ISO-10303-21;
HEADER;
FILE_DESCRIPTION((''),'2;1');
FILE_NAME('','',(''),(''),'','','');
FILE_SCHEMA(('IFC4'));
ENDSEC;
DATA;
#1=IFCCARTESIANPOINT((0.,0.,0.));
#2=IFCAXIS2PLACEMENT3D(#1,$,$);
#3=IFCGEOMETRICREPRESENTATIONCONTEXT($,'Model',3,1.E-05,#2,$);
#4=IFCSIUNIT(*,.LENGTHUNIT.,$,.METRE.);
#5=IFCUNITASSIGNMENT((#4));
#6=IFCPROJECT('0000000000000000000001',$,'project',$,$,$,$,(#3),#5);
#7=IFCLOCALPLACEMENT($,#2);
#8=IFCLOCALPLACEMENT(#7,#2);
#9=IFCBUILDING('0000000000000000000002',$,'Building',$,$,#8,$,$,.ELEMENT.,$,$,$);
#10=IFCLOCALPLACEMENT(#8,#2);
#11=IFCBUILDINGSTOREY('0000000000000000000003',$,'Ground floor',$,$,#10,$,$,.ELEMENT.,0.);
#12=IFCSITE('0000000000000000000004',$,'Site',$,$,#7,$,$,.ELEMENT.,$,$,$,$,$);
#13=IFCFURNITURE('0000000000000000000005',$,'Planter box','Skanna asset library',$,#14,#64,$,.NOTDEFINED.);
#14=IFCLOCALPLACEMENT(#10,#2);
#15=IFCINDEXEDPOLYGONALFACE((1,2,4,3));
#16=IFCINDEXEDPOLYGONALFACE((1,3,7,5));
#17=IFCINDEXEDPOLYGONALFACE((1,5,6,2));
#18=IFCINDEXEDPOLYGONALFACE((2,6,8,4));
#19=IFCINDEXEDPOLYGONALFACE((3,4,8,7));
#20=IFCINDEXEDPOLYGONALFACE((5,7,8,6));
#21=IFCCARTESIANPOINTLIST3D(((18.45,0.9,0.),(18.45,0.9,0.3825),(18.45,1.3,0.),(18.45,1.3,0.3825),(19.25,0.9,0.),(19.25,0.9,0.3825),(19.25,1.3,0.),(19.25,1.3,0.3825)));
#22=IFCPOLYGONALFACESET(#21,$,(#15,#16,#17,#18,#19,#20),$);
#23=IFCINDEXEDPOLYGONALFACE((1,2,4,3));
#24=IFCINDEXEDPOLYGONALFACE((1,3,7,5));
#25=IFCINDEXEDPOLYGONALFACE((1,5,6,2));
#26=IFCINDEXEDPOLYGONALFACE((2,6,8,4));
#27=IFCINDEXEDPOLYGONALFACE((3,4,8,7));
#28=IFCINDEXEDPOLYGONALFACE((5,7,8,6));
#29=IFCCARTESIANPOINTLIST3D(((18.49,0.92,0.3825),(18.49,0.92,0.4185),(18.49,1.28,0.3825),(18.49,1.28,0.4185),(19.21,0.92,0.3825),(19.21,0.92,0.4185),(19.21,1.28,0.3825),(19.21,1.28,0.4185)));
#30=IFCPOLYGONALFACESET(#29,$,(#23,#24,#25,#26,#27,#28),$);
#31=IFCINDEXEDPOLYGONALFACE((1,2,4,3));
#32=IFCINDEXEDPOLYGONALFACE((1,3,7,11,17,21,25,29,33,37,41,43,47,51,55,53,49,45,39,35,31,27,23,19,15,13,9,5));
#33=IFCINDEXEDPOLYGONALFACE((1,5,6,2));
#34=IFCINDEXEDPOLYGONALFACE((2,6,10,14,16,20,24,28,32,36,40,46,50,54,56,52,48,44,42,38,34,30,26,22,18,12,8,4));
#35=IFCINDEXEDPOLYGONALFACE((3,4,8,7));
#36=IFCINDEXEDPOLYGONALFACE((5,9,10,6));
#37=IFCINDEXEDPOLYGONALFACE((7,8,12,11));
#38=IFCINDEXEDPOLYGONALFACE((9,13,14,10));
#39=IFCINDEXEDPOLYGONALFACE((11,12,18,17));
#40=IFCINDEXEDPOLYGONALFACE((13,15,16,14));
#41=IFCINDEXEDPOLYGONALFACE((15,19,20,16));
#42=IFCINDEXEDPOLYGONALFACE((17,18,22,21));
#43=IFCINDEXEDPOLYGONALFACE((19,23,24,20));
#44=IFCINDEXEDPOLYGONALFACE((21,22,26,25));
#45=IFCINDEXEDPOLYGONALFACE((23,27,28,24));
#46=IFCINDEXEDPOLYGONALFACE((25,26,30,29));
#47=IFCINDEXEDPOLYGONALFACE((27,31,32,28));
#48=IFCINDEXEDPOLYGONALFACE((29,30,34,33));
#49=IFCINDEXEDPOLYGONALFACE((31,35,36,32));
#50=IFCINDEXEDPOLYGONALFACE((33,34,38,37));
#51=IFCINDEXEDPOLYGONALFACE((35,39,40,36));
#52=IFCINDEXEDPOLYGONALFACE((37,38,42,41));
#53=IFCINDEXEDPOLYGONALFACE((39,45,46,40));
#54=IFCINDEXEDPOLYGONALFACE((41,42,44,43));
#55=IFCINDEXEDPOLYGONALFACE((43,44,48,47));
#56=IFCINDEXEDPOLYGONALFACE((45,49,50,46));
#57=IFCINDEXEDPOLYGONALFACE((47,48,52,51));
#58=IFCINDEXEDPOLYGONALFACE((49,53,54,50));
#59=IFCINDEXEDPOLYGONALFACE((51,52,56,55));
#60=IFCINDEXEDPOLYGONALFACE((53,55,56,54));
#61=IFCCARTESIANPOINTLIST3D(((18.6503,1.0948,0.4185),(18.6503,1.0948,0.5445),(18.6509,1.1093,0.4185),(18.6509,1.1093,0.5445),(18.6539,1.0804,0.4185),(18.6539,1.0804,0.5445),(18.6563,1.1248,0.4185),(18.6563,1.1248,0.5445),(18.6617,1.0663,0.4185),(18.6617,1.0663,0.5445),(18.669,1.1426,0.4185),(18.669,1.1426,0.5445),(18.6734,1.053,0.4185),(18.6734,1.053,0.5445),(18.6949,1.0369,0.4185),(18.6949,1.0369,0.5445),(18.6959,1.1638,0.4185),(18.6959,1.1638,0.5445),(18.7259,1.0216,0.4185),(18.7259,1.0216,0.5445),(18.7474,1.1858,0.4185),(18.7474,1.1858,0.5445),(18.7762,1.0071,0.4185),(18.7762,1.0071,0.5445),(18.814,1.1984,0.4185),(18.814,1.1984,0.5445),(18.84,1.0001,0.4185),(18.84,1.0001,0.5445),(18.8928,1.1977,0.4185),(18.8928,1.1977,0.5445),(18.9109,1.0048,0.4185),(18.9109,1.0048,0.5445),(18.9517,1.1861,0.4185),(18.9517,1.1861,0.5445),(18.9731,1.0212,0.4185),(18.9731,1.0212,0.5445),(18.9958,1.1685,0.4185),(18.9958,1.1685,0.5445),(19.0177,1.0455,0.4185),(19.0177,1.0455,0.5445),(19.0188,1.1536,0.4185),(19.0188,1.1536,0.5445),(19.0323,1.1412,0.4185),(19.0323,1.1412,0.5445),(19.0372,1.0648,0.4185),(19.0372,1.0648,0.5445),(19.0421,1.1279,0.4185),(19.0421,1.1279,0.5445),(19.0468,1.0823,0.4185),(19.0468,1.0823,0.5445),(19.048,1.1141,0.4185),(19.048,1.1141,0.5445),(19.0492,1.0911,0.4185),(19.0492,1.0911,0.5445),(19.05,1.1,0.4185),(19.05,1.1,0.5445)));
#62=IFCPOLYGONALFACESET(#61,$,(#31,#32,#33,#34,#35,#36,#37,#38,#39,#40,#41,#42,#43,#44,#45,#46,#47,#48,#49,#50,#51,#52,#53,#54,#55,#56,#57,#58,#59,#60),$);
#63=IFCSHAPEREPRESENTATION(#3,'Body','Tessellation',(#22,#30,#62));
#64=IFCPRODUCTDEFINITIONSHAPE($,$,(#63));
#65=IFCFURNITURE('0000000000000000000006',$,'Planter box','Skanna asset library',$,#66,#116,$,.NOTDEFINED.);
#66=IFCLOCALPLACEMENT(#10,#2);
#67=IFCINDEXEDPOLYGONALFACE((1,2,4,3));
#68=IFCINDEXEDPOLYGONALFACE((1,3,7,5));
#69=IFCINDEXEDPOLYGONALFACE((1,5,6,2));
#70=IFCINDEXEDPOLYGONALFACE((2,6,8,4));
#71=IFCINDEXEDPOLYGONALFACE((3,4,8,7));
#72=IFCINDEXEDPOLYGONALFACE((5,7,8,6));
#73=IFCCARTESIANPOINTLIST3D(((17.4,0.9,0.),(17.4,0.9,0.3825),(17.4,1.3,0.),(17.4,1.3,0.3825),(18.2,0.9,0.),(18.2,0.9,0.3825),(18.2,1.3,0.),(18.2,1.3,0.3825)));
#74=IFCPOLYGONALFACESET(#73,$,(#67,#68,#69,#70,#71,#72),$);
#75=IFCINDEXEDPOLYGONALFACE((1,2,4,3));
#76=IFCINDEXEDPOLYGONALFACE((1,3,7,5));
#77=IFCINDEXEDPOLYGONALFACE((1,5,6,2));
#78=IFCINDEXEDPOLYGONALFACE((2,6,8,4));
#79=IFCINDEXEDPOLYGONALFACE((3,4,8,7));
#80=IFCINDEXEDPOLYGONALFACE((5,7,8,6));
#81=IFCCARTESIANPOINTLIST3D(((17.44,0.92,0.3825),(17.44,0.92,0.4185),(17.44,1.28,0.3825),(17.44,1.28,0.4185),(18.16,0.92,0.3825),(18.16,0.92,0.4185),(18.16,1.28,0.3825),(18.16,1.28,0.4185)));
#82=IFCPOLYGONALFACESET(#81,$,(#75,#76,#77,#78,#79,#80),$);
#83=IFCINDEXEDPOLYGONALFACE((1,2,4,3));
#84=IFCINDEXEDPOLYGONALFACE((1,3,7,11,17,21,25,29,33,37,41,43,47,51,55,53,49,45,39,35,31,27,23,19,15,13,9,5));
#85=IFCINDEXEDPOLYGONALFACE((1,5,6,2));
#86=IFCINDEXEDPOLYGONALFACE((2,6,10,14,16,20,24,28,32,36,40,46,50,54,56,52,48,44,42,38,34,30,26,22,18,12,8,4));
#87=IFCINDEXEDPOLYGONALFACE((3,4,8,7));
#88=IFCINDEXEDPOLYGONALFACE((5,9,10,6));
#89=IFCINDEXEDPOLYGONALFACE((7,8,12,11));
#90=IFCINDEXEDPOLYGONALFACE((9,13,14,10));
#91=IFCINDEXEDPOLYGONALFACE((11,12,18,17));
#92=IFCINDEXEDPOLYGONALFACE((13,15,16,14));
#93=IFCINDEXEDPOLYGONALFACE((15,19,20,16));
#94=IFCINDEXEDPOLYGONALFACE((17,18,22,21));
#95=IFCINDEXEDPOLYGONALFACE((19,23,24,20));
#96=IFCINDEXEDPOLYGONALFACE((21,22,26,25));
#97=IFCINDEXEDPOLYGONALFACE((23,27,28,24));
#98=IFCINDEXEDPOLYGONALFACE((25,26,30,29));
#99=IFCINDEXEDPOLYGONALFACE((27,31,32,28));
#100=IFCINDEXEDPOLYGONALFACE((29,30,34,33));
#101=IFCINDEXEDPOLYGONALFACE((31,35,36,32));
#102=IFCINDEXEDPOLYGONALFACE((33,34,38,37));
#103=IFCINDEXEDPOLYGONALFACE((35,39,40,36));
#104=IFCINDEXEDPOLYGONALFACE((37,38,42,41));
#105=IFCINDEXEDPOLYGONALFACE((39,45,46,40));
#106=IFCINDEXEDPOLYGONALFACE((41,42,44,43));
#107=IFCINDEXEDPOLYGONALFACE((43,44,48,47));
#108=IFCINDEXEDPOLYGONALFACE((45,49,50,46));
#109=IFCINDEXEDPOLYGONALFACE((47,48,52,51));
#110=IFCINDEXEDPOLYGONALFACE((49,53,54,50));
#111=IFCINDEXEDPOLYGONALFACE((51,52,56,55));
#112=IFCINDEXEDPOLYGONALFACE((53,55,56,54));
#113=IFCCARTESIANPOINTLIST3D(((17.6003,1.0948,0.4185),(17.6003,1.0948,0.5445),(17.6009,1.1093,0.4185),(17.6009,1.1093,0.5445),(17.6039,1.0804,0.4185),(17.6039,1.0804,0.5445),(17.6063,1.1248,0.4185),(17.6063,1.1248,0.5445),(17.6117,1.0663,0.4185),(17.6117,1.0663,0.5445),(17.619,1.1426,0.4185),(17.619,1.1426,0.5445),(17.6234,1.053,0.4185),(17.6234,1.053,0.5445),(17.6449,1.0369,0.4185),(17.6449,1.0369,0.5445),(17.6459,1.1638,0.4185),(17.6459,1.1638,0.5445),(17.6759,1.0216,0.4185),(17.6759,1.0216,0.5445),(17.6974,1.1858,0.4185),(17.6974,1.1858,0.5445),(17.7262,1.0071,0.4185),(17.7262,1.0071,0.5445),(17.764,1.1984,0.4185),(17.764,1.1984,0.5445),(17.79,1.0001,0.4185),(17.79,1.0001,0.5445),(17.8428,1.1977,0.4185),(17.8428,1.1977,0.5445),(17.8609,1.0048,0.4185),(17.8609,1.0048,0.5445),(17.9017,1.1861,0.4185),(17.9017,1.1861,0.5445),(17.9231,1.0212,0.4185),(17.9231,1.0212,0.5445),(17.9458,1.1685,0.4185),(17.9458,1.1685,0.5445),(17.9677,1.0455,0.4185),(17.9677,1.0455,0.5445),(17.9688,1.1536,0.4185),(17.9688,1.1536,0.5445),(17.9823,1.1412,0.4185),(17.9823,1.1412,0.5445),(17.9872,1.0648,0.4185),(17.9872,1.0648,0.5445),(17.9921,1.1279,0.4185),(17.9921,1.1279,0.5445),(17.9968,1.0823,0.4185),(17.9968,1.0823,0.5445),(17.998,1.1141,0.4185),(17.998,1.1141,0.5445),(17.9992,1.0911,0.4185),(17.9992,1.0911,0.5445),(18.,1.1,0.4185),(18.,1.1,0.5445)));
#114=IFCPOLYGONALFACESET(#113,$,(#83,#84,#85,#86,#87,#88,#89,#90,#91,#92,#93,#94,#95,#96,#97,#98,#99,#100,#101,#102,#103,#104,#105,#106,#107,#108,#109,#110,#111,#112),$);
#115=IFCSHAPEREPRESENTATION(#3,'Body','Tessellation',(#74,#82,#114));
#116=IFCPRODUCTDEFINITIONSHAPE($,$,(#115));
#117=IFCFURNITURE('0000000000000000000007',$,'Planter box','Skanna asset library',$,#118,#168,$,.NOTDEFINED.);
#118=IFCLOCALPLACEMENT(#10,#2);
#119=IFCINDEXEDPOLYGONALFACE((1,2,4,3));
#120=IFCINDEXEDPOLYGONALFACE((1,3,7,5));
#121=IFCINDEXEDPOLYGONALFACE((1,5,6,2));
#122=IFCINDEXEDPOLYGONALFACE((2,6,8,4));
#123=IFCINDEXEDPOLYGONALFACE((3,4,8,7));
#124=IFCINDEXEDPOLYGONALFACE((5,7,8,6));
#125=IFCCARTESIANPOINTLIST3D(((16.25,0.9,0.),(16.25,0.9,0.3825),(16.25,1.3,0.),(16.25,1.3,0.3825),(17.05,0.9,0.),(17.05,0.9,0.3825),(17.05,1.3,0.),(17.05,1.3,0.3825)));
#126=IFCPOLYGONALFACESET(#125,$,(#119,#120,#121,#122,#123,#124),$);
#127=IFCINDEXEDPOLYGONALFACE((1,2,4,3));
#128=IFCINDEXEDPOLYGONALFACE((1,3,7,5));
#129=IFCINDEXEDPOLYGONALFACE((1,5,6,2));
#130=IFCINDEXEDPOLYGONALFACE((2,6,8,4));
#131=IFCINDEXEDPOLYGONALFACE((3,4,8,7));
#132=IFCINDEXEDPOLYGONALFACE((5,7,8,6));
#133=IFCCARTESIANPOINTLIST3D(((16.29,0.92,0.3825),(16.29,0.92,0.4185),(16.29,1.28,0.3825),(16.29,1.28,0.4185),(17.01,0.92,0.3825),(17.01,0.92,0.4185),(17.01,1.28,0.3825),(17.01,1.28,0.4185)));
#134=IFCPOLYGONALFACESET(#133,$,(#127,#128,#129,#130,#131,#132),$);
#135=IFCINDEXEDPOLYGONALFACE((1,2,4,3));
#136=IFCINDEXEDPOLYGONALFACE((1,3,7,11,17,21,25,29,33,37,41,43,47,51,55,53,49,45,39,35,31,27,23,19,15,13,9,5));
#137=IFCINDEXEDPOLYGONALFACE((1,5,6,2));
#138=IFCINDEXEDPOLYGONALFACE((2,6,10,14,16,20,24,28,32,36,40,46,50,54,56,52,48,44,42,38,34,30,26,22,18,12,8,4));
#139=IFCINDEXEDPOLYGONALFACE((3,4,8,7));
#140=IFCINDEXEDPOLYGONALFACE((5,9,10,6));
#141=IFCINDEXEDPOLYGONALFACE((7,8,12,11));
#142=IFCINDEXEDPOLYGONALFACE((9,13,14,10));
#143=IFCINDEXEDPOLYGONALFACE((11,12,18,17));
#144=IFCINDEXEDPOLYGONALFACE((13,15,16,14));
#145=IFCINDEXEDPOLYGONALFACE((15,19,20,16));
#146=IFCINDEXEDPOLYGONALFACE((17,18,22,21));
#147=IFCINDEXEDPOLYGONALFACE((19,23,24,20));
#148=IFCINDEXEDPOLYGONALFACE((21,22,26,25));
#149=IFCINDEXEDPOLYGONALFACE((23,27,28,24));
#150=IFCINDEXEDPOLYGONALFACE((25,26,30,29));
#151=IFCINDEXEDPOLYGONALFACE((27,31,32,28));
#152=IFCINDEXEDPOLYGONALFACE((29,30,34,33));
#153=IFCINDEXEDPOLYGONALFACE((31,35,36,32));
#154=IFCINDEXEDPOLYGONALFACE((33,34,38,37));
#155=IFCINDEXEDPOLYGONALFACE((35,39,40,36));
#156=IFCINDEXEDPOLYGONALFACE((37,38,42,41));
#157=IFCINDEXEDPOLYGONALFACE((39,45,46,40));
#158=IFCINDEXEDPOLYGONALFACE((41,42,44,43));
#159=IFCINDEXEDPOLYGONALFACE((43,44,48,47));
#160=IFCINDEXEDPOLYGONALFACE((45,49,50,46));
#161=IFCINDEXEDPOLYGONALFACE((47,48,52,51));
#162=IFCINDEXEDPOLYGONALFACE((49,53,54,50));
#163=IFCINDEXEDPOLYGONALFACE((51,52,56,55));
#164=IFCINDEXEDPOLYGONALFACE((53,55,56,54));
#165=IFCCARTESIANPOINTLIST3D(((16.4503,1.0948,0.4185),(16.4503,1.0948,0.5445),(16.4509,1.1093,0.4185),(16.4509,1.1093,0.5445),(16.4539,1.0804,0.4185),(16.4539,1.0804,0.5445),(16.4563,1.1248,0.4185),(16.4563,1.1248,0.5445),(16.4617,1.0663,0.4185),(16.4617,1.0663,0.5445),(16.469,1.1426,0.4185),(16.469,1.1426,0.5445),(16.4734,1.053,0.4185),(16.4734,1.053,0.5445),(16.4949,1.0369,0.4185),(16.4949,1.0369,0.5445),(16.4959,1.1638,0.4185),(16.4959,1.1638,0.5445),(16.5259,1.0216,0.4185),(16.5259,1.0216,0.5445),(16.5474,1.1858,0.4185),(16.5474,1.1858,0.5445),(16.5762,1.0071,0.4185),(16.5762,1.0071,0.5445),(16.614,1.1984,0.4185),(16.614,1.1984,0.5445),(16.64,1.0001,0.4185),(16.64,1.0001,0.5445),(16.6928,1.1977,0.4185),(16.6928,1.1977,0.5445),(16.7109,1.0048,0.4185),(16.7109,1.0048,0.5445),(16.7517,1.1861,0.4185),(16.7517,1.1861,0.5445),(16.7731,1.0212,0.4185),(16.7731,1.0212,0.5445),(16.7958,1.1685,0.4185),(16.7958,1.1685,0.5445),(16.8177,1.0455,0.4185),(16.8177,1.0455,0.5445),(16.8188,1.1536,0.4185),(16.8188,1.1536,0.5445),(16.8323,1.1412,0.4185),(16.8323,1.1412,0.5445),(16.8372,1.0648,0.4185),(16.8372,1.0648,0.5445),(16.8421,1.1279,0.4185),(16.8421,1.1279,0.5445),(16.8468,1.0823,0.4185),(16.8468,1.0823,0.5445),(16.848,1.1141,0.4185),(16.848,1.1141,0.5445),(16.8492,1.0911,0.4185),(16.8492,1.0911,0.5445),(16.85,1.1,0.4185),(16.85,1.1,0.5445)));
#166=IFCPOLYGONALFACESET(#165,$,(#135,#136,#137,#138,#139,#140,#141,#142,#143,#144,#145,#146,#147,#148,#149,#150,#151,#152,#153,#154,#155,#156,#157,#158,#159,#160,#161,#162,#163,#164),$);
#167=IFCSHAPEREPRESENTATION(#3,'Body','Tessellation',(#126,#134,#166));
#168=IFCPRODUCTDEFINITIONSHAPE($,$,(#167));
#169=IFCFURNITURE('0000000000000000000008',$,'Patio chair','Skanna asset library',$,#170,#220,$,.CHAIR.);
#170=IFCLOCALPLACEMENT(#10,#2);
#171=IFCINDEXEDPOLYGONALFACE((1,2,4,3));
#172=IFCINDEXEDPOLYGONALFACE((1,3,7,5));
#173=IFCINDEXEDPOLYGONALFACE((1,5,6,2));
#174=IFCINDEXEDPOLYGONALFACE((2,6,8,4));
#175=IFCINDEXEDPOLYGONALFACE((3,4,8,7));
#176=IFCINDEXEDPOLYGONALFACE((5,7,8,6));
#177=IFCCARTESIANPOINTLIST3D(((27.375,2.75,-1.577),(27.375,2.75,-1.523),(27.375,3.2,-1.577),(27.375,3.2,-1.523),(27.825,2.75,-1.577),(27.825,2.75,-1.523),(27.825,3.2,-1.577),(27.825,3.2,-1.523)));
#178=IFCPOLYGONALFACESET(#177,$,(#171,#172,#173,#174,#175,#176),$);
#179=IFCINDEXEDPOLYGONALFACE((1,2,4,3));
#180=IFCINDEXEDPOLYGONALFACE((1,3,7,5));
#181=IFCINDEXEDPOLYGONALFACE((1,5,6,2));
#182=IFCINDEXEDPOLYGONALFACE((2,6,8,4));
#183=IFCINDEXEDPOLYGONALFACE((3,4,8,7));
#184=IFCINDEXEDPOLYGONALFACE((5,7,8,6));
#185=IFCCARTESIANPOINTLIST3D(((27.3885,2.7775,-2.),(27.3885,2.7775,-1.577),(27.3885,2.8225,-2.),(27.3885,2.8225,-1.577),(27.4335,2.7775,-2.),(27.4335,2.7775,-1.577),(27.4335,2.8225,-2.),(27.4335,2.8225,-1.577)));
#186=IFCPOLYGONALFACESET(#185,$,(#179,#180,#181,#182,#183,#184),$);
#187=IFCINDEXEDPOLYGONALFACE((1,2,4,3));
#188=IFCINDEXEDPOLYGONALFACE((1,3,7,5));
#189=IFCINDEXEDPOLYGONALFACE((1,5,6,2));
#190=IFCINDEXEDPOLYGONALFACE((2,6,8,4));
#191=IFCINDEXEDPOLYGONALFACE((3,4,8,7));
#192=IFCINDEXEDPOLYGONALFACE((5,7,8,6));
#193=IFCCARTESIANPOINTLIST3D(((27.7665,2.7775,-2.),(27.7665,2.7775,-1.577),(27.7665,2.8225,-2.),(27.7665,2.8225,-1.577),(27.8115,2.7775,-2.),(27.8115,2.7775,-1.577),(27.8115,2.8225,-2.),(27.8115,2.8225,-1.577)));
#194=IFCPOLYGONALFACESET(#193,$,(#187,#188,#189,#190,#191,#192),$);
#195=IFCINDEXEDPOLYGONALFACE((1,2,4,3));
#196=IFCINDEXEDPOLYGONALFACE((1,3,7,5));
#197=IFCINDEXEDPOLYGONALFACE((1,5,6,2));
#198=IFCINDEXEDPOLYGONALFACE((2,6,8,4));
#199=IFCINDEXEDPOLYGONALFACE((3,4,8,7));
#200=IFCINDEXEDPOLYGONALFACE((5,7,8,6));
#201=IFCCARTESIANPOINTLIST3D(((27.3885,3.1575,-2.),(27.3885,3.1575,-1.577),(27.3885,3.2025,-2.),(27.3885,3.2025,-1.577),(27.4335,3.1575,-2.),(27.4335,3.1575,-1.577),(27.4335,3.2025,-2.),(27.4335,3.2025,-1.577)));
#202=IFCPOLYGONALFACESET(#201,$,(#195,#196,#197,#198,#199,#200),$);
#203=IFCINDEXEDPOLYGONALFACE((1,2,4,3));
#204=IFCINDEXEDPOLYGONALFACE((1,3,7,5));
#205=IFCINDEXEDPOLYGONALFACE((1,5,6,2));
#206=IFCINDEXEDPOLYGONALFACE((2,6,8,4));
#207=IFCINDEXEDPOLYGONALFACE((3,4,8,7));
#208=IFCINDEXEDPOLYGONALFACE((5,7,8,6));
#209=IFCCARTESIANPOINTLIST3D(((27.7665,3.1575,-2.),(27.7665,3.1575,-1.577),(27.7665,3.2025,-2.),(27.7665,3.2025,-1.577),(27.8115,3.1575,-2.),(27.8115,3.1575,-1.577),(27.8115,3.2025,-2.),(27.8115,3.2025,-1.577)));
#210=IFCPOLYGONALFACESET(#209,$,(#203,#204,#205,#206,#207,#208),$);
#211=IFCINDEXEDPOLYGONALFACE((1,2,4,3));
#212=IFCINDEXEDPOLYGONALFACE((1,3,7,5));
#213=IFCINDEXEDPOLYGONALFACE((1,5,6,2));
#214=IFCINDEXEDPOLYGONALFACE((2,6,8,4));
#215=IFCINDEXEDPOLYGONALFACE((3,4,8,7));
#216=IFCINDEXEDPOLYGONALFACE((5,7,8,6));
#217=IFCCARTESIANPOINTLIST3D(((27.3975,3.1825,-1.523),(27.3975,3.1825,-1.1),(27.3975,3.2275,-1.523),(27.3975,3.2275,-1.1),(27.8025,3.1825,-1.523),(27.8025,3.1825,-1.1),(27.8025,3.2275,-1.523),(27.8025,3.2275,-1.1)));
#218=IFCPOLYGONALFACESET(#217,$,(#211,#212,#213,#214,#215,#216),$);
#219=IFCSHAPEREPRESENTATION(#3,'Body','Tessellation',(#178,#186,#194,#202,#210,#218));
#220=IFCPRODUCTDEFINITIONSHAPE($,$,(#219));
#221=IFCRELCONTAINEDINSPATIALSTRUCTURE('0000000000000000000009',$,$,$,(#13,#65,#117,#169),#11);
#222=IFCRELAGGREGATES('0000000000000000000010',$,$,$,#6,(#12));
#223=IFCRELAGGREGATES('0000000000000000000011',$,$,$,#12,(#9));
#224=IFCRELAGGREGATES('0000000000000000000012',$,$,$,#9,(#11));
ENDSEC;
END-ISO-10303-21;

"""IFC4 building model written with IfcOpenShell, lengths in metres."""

from ifc_helpers import new_model, si_unit, frame, frame_2d, origin, origin_2d, place, context, project, spatial, rectangle, ellipse, extrude, element, save


model = new_model("IFC4")

# Units and contexts
model_context = context("Model", 3, precision=1e-05, world=origin())
ifc_project = project(units=[si_unit("LENGTHUNIT", "METRE")], contexts=[model_context])

# Site, building, storey
site_placement = place(None, origin())
site = spatial("IfcSite", under=ifc_project, at=site_placement, Name="Site", CompositionType="ELEMENT")
building_placement = place(site_placement, origin())
building = spatial("IfcBuilding", under=site, at=building_placement, Name="Building", CompositionType="ELEMENT")
storey_placement = place(building_placement, origin())
storey = spatial("IfcBuildingStorey", under=building, at=storey_placement, Name="Ground floor", CompositionType="ELEMENT", Elevation=0.0)

# Furniture
for number, where, z_axis, x_axis, name in (
    (1, (18.85, 1.1, 0.0), (0.0, 0.0, 1.0), (1.0, 0.0, 0.0), "Planter box"),
    (2, (17.8, 1.1, 0.0), (0.0, 0.0, 1.0), (1.0, 0.0, 0.0), "Planter box"),
    (3, (16.65, 1.1, 0.0), (0.0, 0.0, 1.0), (1.0, 0.0, 0.0), "Planter box"),
):
    element("IfcFurniture", number, at=place(storey_placement, frame(where, z_axis=z_axis, x_axis=x_axis)), inside=storey, Name=name, Description="Skanna asset library", PredefinedType="NOTDEFINED", context=model_context, shape_type="SweptSolid", body=[
        extrude(rectangle(XDim=0.8, YDim=0.4, at=origin_2d()), origin(), (0.0, 0.0, 1.0), 0.3825),
        extrude(rectangle(XDim=0.72, YDim=0.36, at=origin_2d()), frame((0.0, 0.0, 0.3825)), (0.0, 0.0, 1.0), 0.036),
        extrude(ellipse(SemiAxis1=0.2, SemiAxis2=0.1, at=origin_2d()), frame((0.0, 0.0, 0.4185)), (0.0, 0.0, 1.0), 0.126),
    ])
for number, where, z_axis, x_axis, name in (
    (4, (27.6, 3.0, -2.0), (0.0, 0.0, 1.0), (1.0, 0.0, 0.0), "Patio chair"),
):
    element("IfcFurniture", number, at=place(storey_placement, frame(where, z_axis=z_axis, x_axis=x_axis)), inside=storey, Name=name, Description="Skanna asset library", PredefinedType="CHAIR", context=model_context, shape_type="SweptSolid", body=[
        extrude(rectangle(XDim=0.45, YDim=0.45, at=frame_2d((0.0, -0.025))), frame((0.0, 0.0, 0.423)), (0.0, 0.0, 1.0), 0.054),
        extrude(rectangle(XDim=0.045, YDim=0.045, at=frame_2d((-0.189, -0.2))), origin(), (0.0, 0.0, 1.0), 0.423),
        extrude(rectangle(XDim=0.045, YDim=0.045, at=frame_2d((0.189, -0.2))), origin(), (0.0, 0.0, 1.0), 0.423),
        extrude(rectangle(XDim=0.045, YDim=0.045, at=frame_2d((-0.189, 0.18))), origin(), (0.0, 0.0, 1.0), 0.423),
        extrude(rectangle(XDim=0.045, YDim=0.045, at=frame_2d((0.189, 0.18))), origin(), (0.0, 0.0, 1.0), 0.423),
        extrude(rectangle(XDim=0.405, YDim=0.045, at=frame_2d((0.0, 0.205))), frame((0.0, 0.0, 0.477)), (0.0, 0.0, 1.0), 0.423),
    ])

save(model, "model.ifc")
